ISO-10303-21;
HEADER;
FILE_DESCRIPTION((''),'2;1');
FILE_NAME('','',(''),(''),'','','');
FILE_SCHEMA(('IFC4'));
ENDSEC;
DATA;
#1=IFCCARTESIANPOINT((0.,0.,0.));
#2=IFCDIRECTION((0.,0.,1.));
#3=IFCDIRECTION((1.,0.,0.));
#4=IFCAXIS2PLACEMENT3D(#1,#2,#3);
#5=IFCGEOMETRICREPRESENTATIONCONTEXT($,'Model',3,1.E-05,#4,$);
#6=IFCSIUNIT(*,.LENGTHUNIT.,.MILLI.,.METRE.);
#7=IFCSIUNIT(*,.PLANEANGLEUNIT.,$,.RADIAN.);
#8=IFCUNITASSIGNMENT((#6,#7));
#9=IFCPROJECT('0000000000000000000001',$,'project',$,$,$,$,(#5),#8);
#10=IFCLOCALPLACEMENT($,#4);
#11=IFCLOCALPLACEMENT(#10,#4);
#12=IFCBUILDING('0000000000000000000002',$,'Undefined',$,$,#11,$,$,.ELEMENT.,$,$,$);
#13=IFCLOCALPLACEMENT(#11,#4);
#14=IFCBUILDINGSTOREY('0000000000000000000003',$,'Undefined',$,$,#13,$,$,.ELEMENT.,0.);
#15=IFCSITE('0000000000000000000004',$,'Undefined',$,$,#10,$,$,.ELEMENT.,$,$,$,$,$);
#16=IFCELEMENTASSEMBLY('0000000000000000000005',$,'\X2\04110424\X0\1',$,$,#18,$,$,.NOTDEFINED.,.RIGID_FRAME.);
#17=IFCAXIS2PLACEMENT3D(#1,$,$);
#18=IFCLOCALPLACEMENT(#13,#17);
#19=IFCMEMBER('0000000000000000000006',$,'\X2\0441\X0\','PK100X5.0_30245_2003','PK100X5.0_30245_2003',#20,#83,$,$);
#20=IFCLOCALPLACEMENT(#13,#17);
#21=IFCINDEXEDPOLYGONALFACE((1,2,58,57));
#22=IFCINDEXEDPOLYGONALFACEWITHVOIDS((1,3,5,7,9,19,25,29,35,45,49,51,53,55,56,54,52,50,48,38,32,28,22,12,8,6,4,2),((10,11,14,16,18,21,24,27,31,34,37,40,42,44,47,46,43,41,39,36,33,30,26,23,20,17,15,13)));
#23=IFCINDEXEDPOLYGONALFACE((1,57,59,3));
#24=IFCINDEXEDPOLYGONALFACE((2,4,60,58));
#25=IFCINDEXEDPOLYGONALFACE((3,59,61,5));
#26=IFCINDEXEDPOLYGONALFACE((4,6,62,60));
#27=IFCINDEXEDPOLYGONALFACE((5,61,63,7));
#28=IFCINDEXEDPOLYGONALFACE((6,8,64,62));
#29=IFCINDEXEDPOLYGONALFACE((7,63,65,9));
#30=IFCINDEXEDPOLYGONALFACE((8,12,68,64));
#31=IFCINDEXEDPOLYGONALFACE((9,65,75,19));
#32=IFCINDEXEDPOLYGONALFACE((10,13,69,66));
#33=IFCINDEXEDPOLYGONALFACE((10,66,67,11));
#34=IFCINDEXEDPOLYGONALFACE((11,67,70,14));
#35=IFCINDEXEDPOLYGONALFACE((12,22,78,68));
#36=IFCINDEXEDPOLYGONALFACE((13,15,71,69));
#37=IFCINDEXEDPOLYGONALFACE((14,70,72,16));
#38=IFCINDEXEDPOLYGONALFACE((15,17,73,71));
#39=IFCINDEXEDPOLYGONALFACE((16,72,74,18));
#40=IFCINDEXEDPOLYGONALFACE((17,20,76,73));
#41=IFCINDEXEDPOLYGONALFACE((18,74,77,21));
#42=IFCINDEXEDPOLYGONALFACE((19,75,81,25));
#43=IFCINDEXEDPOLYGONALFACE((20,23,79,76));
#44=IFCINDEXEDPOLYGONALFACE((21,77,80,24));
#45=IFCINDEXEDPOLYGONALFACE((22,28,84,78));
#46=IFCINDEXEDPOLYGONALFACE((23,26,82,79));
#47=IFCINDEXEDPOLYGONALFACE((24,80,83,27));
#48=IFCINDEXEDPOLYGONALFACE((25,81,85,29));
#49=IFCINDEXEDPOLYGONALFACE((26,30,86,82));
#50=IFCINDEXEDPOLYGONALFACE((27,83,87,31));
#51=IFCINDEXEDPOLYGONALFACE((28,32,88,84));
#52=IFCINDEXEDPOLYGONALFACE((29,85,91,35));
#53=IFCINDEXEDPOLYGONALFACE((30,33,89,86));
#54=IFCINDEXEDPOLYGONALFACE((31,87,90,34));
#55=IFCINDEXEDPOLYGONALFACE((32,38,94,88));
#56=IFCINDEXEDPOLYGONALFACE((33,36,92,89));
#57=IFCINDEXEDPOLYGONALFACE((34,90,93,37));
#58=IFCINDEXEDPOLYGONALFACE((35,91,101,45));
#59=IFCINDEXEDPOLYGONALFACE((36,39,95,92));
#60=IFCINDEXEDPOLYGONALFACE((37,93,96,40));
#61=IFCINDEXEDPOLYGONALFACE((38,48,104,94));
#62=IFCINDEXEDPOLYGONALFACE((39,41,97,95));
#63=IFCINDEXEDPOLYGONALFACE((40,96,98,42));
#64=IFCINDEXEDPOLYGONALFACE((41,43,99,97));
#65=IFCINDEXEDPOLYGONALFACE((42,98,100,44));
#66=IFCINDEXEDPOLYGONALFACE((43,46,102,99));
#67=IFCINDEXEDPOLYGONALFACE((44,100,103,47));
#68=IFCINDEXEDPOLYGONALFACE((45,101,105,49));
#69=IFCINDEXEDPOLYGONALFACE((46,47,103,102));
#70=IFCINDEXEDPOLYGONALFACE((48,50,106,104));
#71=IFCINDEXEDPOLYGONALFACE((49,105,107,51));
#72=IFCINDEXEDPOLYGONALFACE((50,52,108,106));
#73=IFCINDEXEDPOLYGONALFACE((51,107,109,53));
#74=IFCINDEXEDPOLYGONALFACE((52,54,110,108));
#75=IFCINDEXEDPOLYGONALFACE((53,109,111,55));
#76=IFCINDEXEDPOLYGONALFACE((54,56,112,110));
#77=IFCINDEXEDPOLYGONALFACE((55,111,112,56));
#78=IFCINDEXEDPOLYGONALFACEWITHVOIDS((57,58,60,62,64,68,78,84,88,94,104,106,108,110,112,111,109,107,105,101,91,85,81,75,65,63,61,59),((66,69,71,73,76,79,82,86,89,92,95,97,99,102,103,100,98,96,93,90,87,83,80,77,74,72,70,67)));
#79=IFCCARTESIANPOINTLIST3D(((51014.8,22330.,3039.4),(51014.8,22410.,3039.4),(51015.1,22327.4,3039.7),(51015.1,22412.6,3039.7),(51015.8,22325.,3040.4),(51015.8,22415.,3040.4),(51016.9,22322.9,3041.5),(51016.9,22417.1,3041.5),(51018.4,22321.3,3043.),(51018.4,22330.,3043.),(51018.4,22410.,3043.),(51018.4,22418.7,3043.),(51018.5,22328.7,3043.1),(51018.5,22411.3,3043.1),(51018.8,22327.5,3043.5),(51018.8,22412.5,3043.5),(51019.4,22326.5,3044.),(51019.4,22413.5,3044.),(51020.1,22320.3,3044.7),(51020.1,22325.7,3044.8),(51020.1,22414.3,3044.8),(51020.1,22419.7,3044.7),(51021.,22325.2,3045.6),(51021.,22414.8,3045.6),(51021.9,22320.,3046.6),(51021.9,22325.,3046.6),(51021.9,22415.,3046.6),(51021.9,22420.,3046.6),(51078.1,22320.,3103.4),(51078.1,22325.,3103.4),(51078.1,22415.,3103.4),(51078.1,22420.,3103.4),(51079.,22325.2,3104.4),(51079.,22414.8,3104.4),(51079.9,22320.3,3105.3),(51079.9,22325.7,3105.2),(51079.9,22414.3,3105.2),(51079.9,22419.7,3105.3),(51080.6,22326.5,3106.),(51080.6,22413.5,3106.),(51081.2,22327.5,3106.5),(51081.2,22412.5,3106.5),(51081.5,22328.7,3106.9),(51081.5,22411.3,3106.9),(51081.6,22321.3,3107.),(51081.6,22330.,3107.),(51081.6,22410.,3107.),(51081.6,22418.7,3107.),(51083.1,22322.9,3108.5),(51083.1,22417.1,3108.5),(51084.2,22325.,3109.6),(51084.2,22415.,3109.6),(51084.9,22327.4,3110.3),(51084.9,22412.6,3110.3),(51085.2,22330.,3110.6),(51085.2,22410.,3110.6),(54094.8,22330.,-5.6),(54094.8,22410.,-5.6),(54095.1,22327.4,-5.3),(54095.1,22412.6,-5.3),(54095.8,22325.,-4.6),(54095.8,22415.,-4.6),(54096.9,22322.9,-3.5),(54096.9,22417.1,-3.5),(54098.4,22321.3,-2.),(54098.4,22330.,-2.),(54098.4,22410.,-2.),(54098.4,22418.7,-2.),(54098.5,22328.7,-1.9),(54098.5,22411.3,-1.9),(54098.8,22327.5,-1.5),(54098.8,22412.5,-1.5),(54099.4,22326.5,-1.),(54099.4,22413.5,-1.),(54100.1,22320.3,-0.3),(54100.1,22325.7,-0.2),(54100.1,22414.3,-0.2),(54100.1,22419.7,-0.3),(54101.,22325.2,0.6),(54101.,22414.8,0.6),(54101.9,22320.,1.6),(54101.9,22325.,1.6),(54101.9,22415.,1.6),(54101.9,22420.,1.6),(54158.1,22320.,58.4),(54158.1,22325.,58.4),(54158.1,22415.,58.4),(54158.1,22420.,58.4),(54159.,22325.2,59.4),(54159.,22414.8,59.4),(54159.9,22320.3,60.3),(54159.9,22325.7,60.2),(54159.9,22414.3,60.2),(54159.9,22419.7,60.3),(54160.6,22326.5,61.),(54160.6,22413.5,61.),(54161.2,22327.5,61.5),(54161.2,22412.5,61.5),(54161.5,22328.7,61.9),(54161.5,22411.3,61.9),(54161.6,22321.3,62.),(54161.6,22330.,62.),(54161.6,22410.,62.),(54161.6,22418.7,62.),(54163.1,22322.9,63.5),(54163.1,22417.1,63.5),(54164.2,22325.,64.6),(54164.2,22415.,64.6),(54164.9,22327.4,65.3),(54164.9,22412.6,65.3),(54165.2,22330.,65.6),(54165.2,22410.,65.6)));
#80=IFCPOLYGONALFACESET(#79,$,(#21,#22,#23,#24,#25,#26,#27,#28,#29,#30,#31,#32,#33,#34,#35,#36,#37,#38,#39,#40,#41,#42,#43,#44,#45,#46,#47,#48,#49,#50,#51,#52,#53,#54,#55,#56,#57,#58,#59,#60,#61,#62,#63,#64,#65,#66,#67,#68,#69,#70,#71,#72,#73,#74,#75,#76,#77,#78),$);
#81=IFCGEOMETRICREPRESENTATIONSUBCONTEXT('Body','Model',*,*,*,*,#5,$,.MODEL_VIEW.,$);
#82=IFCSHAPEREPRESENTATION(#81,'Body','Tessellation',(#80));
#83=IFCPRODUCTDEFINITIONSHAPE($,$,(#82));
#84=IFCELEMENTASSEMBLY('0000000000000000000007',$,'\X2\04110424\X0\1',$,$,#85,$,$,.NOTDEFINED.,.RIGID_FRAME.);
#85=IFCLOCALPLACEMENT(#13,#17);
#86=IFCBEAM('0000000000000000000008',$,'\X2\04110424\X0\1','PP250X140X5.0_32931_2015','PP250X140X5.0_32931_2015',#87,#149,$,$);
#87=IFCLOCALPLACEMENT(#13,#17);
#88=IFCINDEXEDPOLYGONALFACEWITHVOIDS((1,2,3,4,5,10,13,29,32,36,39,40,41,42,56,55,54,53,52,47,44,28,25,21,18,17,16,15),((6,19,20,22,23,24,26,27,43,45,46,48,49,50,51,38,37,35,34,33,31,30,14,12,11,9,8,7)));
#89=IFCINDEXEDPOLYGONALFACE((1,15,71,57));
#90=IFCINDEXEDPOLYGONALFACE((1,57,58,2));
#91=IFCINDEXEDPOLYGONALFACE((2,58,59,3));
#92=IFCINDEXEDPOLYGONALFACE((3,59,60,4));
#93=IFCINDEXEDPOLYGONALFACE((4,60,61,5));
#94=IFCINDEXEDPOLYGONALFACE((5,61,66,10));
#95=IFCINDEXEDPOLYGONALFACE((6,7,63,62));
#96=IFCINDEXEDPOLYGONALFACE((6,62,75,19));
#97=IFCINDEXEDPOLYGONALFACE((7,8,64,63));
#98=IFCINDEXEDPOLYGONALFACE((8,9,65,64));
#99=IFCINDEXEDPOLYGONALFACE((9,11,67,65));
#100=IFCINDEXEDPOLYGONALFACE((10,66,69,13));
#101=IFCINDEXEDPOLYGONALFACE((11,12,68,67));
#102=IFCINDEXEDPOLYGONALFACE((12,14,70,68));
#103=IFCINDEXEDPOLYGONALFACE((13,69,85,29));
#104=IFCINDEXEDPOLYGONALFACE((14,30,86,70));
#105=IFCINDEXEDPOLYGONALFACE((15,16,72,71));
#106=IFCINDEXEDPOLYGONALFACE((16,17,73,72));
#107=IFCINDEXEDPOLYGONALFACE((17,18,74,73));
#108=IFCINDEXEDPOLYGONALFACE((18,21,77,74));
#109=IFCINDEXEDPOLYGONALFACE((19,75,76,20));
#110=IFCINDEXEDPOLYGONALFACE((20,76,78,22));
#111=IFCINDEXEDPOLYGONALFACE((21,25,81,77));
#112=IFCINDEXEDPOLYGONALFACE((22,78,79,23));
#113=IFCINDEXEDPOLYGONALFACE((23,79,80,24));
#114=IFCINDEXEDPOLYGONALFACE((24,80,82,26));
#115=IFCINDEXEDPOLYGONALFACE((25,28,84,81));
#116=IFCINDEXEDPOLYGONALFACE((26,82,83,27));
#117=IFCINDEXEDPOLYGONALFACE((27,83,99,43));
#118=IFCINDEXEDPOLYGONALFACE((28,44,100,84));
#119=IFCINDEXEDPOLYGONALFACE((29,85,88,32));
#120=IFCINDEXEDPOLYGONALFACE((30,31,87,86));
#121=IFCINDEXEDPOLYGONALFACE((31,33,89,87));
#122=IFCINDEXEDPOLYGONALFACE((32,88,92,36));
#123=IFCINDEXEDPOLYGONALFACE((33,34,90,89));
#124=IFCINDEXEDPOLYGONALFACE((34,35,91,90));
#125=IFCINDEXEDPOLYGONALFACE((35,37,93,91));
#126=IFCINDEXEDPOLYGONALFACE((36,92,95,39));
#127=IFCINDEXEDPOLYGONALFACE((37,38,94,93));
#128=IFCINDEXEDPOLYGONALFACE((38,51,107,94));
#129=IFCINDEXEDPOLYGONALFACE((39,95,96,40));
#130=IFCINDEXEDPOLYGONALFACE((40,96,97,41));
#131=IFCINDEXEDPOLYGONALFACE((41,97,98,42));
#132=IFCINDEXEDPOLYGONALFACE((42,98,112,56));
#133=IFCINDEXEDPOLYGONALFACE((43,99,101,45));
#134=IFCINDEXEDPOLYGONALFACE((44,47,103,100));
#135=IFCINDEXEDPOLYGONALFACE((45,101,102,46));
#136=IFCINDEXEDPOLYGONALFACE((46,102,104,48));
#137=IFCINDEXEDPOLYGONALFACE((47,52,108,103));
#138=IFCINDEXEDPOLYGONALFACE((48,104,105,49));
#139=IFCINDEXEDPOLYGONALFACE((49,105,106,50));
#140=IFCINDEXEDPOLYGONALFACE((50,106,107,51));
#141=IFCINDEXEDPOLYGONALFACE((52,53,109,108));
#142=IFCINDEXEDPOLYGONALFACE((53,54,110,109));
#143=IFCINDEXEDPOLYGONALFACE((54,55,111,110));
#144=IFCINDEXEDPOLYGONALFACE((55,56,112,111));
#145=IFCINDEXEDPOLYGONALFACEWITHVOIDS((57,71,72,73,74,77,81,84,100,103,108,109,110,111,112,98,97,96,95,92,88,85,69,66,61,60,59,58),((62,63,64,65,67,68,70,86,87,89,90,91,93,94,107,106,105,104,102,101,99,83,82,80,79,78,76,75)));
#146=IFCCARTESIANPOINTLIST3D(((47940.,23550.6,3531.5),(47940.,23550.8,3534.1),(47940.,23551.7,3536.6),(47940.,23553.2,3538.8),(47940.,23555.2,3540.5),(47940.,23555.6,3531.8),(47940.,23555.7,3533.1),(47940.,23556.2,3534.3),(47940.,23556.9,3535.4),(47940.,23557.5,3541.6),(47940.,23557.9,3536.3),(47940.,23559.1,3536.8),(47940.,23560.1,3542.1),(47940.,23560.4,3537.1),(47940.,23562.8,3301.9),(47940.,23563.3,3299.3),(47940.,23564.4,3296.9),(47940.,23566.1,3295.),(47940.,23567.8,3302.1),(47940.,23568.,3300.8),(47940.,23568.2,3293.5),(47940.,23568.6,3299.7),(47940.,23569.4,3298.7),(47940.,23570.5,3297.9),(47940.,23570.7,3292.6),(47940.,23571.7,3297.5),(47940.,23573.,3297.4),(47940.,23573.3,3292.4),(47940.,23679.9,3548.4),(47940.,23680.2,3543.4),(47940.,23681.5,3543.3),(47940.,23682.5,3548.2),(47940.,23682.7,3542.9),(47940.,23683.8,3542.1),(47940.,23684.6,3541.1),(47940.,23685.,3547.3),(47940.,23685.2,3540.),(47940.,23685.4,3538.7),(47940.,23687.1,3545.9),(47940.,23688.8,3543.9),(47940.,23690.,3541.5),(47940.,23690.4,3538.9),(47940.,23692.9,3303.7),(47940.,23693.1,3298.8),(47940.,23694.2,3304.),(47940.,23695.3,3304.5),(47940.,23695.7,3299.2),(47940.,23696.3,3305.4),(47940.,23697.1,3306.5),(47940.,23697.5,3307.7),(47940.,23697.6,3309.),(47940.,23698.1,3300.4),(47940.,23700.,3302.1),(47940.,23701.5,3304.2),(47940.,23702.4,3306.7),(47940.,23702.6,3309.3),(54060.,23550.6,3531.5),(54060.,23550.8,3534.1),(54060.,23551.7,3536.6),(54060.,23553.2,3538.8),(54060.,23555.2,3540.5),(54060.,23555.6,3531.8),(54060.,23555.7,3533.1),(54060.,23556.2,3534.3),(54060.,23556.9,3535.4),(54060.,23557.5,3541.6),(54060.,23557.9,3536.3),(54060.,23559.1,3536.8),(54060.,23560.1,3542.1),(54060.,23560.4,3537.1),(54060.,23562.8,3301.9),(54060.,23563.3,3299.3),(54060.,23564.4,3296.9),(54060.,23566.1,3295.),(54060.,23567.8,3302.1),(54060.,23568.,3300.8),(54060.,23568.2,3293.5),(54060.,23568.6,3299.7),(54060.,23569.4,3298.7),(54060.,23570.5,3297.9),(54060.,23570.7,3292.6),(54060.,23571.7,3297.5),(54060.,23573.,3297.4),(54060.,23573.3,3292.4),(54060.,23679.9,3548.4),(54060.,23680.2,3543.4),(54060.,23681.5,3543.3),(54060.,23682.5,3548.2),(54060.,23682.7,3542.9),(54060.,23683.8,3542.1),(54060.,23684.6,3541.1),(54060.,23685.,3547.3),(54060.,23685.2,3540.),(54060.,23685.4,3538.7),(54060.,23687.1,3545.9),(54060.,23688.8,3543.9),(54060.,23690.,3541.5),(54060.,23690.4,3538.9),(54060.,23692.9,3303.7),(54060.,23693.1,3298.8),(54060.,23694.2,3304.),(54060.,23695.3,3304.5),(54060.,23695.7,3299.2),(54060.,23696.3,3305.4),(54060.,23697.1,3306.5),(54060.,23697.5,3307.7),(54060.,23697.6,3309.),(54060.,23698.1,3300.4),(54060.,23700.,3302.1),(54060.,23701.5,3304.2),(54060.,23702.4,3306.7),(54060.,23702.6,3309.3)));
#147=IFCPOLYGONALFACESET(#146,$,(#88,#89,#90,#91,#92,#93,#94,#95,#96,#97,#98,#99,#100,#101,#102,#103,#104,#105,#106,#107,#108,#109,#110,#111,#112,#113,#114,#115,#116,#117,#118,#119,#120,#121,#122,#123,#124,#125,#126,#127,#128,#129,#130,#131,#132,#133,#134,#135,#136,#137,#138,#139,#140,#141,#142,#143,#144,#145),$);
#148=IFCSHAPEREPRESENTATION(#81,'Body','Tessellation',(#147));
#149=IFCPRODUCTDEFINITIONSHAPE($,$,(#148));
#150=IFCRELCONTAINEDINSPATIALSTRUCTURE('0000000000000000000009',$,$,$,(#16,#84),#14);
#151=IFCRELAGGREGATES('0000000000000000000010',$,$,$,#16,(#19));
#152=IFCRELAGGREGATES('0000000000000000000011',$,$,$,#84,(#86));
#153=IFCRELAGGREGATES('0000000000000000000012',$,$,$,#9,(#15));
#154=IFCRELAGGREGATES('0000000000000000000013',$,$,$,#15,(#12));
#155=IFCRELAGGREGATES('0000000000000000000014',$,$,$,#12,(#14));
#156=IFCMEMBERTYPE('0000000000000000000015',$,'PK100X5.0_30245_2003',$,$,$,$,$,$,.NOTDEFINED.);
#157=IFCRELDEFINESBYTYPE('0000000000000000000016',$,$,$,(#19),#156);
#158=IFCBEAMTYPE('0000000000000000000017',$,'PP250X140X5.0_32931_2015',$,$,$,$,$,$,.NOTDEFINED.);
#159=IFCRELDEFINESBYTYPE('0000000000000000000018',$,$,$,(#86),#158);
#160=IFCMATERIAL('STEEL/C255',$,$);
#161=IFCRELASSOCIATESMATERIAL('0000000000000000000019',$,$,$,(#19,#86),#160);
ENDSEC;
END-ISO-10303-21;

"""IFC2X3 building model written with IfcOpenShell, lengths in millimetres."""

from ifc_helpers import new_model, si_unit, frame, origin_with_axes, origin_2d_with_axis, place, context, subcontext, project, spatial, hollow_rectangle, extrude, material, type_object, element, aggregate, save


model = new_model("IFC2X3")

# Units and contexts
model_context = context("Model", 3, precision=1e-05, world=origin_with_axes())
body_context = subcontext(model_context, "Body", "Model", "MODEL_VIEW")
ifc_project = project(units=[si_unit("LENGTHUNIT", "METRE", prefix="MILLI"), si_unit("PLANEANGLEUNIT", "RADIAN")], contexts=[model_context])

# Site, building, storey
site_placement = place(None, origin_with_axes())
site = spatial("IfcSite", under=ifc_project, at=site_placement, Name="Undefined", CompositionType="ELEMENT")
building_placement = place(site_placement, origin_with_axes())
building = spatial("IfcBuilding", under=site, at=building_placement, Name="Undefined", CompositionType="ELEMENT")
storey_placement = place(building_placement, origin_with_axes())
storey = spatial("IfcBuildingStorey", under=building, at=storey_placement, Name="Undefined", CompositionType="ELEMENT", Elevation=0.0)

# Shared definitions
ifc_material_1 = material(Name="STEEL/C255")

# Element assembly, member
assembly_1_placement = place(storey_placement, origin_with_axes())
assembly_1 = element("IfcElementAssembly", 1, at=assembly_1_placement, inside=storey, Name="БФ1", AssemblyPlace="NOTDEFINED", PredefinedType="RIGID_FRAME")
member_type_1 = type_object("IfcMemberType", Name="PK100X5.0_30245_2003", PredefinedType="NOTDEFINED")
member_1_placement = place(assembly_1_placement, frame((54130.0, 22370.0, 30.0), z_axis=(0.0, -1.0, 0.0), x_axis=(-0.711136, 0.0, 0.703055)))
member_1 = element("IfcMember", 2, at=member_1_placement, type_object=member_type_1, material=ifc_material_1, Name="с", Description="PK100X5.0_30245_2003", ObjectType="PK100X5.0_30245_2003", context=body_context, shape_type="SweptSolid", body=[
    extrude(hollow_rectangle(XDim=100.0, YDim=100.0, WallThickness=5.0, InnerFilletRadius=5.0, OuterFilletRadius=10.0, at=origin_2d_with_axis()), frame((4331.1, 0.0, 0.0), z_axis=(-1.0, 0.0, 0.0), x_axis=(0.0, -1.0, 0.0)), (0.0, 0.0, 1.0), 4331.1),
])
aggregate(assembly_1, [member_1])

# Element assembly, beam
assembly_2_placement = place(storey_placement, origin_with_axes())
assembly_2 = element("IfcElementAssembly", 3, at=assembly_2_placement, inside=storey, Name="БФ1", AssemblyPlace="NOTDEFINED", PredefinedType="RIGID_FRAME")
beam_type_1 = type_object("IfcBeamType", Name="PP250X140X5.0_32931_2015", PredefinedType="NOTDEFINED")
beam_1_placement = place(assembly_2_placement, frame((54060.0, 23626.6, 3420.4), z_axis=(0.0, 0.052867, -0.998602), x_axis=(-1.0, 0.0, 0.0)))
beam_1 = element("IfcBeam", 4, at=beam_1_placement, type_object=beam_type_1, material=ifc_material_1, Name="БФ1", Description="PP250X140X5.0_32931_2015", ObjectType="PP250X140X5.0_32931_2015", context=body_context, shape_type="SweptSolid", body=[
    extrude(hollow_rectangle(XDim=140.0, YDim=250.0, WallThickness=5.0, InnerFilletRadius=5.0, OuterFilletRadius=10.0, at=origin_2d_with_axis()), frame((6120.0, 0.0, 0.0), z_axis=(-1.0, 0.0, 0.0), x_axis=(0.0, -1.0, 0.0)), (0.0, 0.0, 1.0), 6120.0),
])
aggregate(assembly_2, [beam_1])

save(model, "model.ifc")
